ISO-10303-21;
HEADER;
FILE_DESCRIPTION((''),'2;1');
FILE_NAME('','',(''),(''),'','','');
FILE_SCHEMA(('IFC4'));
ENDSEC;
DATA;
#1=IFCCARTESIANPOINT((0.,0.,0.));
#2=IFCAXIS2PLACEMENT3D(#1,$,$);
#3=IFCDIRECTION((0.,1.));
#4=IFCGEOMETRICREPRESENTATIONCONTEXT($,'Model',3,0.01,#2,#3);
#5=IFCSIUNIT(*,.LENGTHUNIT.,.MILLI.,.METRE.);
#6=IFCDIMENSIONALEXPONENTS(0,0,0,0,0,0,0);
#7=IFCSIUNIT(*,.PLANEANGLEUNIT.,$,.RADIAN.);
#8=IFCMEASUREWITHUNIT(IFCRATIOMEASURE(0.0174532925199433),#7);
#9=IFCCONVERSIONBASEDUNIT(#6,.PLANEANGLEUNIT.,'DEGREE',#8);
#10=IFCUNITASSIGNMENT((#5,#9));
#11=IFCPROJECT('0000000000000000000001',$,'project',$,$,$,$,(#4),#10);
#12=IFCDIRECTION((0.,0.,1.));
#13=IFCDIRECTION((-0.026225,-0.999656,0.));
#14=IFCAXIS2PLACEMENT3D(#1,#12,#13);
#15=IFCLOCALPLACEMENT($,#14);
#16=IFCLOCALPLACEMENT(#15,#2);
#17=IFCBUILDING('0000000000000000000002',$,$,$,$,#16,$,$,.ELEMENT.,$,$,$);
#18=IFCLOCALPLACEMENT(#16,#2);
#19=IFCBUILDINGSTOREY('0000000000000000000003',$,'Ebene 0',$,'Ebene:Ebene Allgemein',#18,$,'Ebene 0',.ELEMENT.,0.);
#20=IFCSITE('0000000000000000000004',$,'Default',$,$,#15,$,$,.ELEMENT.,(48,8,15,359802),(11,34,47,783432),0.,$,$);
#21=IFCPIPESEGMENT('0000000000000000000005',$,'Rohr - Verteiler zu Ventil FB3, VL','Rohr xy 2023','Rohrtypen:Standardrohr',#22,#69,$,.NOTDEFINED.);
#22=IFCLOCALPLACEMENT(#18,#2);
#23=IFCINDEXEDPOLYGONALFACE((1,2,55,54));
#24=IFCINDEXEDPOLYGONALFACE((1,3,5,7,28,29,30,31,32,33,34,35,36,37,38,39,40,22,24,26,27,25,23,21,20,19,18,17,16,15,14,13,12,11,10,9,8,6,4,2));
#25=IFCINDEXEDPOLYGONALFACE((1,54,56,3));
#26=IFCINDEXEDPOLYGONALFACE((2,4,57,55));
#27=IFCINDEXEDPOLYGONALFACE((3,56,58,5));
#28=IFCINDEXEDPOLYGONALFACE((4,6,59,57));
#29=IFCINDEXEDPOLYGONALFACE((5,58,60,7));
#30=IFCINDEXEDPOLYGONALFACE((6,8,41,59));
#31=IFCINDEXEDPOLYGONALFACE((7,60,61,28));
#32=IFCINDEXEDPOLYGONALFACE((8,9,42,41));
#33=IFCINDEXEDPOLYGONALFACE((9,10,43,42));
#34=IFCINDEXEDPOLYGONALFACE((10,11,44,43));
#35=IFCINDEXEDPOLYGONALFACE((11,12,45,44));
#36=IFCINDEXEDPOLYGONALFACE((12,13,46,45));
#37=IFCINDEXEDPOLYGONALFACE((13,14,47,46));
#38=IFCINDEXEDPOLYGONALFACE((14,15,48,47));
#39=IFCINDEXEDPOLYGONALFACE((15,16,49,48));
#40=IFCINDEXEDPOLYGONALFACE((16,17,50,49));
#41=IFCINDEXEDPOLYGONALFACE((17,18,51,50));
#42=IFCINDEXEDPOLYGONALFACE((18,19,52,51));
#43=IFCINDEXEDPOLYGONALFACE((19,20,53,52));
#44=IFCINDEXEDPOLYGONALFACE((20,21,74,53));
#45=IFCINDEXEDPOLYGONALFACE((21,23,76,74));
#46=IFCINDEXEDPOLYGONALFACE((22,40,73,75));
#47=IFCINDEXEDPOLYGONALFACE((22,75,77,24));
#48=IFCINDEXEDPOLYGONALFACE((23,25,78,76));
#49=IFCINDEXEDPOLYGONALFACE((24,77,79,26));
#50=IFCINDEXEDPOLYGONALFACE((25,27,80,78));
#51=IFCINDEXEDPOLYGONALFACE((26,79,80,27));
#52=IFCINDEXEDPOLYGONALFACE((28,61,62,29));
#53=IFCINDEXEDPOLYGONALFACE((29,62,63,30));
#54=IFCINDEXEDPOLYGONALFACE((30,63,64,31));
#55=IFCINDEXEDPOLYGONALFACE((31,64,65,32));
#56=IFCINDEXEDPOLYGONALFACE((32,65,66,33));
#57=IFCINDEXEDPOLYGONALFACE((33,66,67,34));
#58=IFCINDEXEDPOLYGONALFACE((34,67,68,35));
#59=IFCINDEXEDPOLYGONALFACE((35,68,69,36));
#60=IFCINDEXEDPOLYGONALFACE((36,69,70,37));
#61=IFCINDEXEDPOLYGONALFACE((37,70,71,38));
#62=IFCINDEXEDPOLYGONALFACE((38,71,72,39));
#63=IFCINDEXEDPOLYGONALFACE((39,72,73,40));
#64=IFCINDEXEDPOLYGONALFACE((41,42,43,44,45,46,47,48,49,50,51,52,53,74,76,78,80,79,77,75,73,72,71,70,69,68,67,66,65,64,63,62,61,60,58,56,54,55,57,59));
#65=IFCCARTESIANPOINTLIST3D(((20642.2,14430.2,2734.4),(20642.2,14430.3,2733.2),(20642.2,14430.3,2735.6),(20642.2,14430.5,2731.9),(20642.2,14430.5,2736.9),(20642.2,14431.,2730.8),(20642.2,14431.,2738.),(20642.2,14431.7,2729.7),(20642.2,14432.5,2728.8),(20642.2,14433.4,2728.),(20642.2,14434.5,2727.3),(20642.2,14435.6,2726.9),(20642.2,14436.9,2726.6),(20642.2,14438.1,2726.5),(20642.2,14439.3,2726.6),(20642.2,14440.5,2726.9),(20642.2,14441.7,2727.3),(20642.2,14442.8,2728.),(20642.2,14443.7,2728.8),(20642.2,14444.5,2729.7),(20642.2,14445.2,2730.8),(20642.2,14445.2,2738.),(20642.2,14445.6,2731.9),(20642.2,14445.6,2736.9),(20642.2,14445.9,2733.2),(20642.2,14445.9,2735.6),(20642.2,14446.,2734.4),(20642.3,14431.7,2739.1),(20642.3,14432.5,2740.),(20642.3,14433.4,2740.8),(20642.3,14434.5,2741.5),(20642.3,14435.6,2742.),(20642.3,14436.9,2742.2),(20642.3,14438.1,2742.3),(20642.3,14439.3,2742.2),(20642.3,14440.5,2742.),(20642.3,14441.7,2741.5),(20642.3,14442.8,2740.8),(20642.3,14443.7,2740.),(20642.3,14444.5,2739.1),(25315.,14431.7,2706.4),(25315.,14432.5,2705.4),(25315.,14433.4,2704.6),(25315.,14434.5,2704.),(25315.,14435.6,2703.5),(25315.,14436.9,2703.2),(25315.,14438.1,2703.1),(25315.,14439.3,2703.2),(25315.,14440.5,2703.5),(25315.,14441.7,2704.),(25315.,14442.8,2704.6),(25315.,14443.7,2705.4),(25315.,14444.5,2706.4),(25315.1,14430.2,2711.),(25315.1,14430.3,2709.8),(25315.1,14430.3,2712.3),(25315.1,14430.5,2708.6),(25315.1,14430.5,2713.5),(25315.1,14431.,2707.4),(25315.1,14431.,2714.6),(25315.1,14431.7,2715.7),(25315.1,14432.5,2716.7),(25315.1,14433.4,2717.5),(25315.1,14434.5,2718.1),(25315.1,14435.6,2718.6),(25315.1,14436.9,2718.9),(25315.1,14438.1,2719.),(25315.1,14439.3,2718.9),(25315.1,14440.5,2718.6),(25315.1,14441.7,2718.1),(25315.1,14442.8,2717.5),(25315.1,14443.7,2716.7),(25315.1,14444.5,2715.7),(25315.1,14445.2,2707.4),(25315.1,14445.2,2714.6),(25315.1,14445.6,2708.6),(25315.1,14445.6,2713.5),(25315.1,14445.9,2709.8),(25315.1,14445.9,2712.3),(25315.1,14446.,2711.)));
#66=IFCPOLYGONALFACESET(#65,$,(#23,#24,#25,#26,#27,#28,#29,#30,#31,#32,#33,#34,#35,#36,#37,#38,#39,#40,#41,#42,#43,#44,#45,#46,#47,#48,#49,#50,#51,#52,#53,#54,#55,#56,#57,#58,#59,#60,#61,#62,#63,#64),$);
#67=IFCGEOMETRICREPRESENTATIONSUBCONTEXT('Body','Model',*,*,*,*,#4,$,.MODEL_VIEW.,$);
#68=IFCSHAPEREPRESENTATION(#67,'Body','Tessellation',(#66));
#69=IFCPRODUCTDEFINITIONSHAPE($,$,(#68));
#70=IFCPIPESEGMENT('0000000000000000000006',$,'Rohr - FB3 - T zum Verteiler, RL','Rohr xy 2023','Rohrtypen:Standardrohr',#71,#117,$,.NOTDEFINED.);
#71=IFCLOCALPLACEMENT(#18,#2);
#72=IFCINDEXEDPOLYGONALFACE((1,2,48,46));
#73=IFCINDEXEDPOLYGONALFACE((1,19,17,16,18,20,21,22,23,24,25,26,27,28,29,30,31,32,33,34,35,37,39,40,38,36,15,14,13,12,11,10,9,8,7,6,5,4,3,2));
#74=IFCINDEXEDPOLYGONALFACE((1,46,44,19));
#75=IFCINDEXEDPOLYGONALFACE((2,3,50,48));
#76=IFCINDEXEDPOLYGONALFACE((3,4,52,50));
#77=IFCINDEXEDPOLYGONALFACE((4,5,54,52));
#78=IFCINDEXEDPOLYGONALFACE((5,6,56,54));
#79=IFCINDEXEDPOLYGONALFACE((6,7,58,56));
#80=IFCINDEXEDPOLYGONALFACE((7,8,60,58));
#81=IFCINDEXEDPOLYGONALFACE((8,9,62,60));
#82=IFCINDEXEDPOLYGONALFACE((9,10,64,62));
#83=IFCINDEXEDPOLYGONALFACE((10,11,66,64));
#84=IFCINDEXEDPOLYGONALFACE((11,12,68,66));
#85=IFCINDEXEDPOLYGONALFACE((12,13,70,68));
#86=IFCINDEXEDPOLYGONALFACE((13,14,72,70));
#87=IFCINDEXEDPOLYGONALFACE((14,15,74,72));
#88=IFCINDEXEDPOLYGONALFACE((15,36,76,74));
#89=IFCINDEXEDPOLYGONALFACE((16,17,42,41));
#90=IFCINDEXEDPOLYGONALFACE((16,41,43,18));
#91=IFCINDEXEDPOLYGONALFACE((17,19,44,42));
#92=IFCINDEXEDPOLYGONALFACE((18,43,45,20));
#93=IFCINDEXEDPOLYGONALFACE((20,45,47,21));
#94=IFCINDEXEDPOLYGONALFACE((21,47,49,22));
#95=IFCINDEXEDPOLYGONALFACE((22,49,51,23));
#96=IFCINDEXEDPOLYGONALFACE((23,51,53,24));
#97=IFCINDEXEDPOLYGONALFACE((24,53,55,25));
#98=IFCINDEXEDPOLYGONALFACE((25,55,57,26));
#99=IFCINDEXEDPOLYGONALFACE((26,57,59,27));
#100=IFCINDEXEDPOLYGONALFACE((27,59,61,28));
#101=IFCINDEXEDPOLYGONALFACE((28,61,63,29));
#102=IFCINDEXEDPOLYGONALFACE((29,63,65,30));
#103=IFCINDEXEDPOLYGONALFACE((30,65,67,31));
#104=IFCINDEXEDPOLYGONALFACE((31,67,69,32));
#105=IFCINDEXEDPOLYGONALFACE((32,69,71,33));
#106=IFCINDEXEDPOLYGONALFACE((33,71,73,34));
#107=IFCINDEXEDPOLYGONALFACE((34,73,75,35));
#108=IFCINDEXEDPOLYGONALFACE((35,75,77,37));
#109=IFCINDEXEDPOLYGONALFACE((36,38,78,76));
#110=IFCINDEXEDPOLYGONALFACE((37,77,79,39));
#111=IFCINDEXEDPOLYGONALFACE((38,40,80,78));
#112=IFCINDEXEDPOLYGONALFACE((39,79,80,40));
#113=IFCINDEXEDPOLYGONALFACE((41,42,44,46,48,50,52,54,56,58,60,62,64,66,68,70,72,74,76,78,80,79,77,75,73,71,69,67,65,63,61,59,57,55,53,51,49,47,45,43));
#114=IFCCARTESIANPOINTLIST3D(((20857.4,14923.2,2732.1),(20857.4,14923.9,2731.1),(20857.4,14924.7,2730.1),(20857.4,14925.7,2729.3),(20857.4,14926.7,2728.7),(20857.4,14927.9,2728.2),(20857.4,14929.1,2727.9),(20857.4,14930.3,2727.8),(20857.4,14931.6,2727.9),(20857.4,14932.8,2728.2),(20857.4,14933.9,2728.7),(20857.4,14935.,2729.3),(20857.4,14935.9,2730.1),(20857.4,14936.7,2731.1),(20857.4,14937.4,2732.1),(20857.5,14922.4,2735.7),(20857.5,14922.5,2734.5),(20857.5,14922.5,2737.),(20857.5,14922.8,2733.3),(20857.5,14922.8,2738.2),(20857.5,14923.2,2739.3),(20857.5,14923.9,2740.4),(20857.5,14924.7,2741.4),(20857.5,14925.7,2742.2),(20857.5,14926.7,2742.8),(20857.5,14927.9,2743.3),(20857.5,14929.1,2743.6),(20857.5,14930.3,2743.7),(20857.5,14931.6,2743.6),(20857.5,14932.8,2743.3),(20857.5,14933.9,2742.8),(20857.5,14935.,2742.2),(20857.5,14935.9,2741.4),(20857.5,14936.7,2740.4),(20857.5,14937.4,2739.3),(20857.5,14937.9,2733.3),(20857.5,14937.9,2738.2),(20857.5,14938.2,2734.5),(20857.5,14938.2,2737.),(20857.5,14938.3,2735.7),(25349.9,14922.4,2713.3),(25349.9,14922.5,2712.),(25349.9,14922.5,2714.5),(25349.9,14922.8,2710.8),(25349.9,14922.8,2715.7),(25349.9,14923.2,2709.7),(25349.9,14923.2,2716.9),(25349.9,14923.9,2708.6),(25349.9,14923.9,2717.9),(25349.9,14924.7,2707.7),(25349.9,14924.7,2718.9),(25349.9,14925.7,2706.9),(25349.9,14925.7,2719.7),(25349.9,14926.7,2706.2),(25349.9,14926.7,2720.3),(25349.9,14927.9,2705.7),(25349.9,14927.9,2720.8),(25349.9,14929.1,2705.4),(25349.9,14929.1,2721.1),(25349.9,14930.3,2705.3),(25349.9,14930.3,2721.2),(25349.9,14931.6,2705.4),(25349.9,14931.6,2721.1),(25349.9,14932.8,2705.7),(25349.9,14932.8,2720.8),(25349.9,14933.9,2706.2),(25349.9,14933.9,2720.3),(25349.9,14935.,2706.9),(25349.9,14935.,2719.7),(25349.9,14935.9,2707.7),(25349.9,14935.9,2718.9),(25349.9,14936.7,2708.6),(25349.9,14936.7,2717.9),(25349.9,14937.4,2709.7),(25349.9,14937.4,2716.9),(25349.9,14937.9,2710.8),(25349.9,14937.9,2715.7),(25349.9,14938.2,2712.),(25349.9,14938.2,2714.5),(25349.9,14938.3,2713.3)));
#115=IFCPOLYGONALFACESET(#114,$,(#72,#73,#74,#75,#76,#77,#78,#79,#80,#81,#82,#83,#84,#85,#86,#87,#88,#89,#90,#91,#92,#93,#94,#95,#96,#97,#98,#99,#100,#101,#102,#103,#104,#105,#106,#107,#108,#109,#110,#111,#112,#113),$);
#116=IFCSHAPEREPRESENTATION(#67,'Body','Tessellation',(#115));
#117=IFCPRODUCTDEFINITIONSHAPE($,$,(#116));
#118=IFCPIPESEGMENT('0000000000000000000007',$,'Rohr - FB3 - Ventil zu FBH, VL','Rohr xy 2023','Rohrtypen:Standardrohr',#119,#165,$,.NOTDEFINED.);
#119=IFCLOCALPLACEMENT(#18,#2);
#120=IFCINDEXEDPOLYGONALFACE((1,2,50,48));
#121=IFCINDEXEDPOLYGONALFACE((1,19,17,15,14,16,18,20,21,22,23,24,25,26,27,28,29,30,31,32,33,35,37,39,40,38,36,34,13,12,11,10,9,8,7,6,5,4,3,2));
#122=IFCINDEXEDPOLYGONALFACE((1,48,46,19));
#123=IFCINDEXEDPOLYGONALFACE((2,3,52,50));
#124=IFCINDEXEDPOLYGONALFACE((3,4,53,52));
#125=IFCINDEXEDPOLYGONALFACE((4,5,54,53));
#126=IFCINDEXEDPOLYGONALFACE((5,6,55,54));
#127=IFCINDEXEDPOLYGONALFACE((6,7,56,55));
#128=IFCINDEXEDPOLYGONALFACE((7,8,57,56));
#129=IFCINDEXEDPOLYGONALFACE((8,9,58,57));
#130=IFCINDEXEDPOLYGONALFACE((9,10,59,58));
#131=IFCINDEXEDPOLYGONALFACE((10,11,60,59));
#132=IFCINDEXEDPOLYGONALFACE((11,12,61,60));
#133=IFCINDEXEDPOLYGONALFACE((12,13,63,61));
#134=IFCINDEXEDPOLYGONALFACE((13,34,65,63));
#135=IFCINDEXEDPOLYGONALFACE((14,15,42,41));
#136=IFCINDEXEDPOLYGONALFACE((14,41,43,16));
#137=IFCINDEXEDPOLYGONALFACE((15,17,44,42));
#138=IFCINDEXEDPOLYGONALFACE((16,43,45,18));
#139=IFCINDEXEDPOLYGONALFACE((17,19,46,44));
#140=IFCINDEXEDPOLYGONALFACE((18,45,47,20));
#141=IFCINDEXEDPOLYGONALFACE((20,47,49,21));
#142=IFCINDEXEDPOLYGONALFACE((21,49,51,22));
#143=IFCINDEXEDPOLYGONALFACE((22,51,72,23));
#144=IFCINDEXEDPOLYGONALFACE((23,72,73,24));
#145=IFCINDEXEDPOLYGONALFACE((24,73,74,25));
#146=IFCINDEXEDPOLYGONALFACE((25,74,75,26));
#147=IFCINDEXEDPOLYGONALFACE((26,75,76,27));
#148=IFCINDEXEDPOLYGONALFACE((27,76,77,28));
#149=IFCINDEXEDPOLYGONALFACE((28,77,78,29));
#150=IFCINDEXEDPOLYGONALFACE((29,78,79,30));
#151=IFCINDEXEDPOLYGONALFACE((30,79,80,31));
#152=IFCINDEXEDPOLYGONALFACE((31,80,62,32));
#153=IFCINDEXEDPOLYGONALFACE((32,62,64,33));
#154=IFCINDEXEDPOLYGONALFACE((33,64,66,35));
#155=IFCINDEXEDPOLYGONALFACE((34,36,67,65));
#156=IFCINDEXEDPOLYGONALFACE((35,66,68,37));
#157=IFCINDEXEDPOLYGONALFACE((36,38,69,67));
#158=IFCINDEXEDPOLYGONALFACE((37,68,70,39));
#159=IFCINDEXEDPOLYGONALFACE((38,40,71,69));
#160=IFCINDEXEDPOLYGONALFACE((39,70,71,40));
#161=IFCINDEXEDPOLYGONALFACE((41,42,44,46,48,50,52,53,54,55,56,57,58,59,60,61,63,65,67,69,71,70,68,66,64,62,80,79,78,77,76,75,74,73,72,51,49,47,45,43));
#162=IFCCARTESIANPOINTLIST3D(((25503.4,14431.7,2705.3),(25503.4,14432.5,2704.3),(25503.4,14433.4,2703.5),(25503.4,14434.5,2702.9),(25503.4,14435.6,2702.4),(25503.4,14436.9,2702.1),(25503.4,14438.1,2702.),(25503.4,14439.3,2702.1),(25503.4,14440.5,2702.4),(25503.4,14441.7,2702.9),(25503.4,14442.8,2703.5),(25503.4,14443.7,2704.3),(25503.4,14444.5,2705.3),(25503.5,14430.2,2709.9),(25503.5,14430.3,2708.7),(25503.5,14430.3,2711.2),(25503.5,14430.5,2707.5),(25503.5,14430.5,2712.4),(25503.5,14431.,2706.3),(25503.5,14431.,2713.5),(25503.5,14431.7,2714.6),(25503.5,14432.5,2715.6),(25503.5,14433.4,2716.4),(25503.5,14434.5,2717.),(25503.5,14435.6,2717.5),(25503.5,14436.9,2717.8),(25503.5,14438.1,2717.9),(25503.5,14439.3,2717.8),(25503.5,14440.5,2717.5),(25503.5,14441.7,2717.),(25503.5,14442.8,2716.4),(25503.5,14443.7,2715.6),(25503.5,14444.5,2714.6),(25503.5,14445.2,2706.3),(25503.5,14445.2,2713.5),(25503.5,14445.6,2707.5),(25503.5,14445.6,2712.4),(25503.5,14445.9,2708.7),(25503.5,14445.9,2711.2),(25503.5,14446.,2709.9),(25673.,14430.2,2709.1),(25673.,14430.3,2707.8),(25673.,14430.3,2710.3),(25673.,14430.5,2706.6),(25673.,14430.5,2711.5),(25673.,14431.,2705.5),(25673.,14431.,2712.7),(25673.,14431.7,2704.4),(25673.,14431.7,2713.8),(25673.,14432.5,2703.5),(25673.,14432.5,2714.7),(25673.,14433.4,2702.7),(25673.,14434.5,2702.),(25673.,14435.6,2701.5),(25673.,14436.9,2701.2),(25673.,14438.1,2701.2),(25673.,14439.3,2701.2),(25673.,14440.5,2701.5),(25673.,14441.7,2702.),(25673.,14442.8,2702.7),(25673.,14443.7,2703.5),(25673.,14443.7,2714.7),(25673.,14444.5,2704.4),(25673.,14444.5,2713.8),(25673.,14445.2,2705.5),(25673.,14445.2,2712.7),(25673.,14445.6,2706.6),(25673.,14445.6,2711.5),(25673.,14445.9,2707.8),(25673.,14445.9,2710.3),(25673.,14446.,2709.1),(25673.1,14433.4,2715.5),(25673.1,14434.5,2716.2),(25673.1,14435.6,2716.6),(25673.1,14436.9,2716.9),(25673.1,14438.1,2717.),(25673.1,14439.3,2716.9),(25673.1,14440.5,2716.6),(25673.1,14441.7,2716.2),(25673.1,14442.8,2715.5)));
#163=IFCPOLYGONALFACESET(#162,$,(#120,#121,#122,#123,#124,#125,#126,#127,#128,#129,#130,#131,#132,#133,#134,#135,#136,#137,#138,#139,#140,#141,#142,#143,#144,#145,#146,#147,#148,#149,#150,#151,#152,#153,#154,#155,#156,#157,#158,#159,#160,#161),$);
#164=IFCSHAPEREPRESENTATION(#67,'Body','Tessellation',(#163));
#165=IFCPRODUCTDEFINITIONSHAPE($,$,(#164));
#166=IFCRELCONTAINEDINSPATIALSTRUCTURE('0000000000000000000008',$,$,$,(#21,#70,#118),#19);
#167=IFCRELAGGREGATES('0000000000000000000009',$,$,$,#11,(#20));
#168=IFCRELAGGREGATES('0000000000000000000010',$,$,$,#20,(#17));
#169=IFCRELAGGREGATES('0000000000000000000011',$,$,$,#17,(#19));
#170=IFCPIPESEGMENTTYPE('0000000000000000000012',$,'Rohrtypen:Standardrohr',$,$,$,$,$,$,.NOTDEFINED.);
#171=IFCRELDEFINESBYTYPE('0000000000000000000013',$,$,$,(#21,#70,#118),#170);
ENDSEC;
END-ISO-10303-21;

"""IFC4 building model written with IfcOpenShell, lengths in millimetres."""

from ifc_helpers import new_model, entity, si_unit, converted_unit, direction, frame, origin, place, context, subcontext, project, spatial, indexed_curve, outline, extrude, type_object, element, save


model = new_model("IFC4")

# Units and contexts
model_context = context("Model", 3, precision=0.01, world=origin(), true_north=direction((0.0, 1.0)))
body_context = subcontext(model_context, "Body", "Model", "MODEL_VIEW")
ifc_project = project(units=[si_unit("LENGTHUNIT", "METRE", prefix="MILLI"), converted_unit("PLANEANGLEUNIT", "DEGREE", entity("IfcRatioMeasure", 0.0174532925199433), si_unit("PLANEANGLEUNIT", "RADIAN"), dimensions=[0, 0, 0, 0, 0, 0, 0])], contexts=[model_context])

# Site, building, storey
site_placement = place(None, frame((0.0, 0.0, 0.0), z_axis=(0.0, 0.0, 1.0), x_axis=(-0.026225, -0.999656, 0.0)))
site = spatial("IfcSite", under=ifc_project, at=site_placement, Name="Default", CompositionType="ELEMENT", RefLatitude=(48, 8, 15, 359802), RefLongitude=(11, 34, 47, 783432), RefElevation=0.0)
building_placement = place(site_placement, origin())
building = spatial("IfcBuilding", under=site, at=building_placement, CompositionType="ELEMENT")
storey_placement = place(building_placement, origin())
storey = spatial("IfcBuildingStorey", under=building, at=storey_placement, Name="Ebene 0", ObjectType="Ebene:Ebene Allgemein", LongName="Ebene 0", CompositionType="ELEMENT", Elevation=0.0)

# Pipe segments
pipe_segment_type = type_object("IfcPipeSegmentType", Name="Rohrtypen:Standardrohr", PredefinedType="NOTDEFINED")
pipe_segment_1_placement = place(storey_placement, origin())
element("IfcPipeSegment", 1, at=pipe_segment_1_placement, inside=storey, type_object=pipe_segment_type, Name="Rohr - Verteiler zu Ventil FB3, VL", Description="Rohr xy 2023", ObjectType="Rohrtypen:Standardrohr", PredefinedType="NOTDEFINED", context=body_context, shape_type="SweptSolid", body=[
    extrude(outline(indexed_curve([(7.9, 0.0), (7.8, 1.2), (7.6, 2.5), (7.1, 3.6), (6.4, 4.7), (5.6, 5.6), (4.7, 6.4), (3.6, 7.1), (2.5, 7.6), (1.2, 7.8), (0.0, 7.9), (-1.2, 7.8), (-2.5, 7.6), (-3.6, 7.1), (-4.7, 6.4), (-5.6, 5.6), (-6.4, 4.7), (-7.1, 3.6), (-7.6, 2.5), (-7.8, 1.2), (-7.9, 0.0), (-7.8, -1.2), (-7.6, -2.5), (-7.1, -3.6), (-6.4, -4.7), (-5.6, -5.6), (-4.7, -6.4), (-3.6, -7.1), (-2.5, -7.6), (-1.2, -7.8), (0.0, -7.9), (1.2, -7.8), (2.5, -7.6), (3.6, -7.1), (4.7, -6.4), (5.6, -5.6), (6.4, -4.7), (7.1, -3.6), (7.6, -2.5), (7.8, -1.2), (7.9, 0.0)], self_intersect=False)), frame((25315.1, 14438.1, 2711.0), z_axis=(-0.999988, 0.0, 0.005), x_axis=(0.0, 1.0, 0.0)), (0.0, 0.0, 1.0), 4672.9),
])
pipe_segment_2_placement = place(storey_placement, origin())
element("IfcPipeSegment", 2, at=pipe_segment_2_placement, inside=storey, type_object=pipe_segment_type, Name="Rohr - FB3 - T zum Verteiler, RL", Description="Rohr xy 2023", ObjectType="Rohrtypen:Standardrohr", PredefinedType="NOTDEFINED", context=body_context, shape_type="SweptSolid", body=[
    extrude(outline(indexed_curve([(7.9, 0.0), (7.8, 1.2), (7.6, 2.5), (7.1, 3.6), (6.4, 4.7), (5.6, 5.6), (4.7, 6.4), (3.6, 7.1), (2.5, 7.6), (1.2, 7.8), (0.0, 7.9), (-1.2, 7.8), (-2.5, 7.6), (-3.6, 7.1), (-4.7, 6.4), (-5.6, 5.6), (-6.4, 4.7), (-7.1, 3.6), (-7.6, 2.5), (-7.8, 1.2), (-7.9, 0.0), (-7.8, -1.2), (-7.6, -2.5), (-7.1, -3.6), (-6.4, -4.7), (-5.6, -5.6), (-4.7, -6.4), (-3.6, -7.1), (-2.5, -7.6), (-1.2, -7.8), (0.0, -7.9), (1.2, -7.8), (2.5, -7.6), (3.6, -7.1), (4.7, -6.4), (5.6, -5.6), (6.4, -4.7), (7.1, -3.6), (7.6, -2.5), (7.8, -1.2), (7.9, 0.0)], self_intersect=False)), frame((25349.9, 14930.3, 2713.3), z_axis=(-0.999988, 0.0, 0.005), x_axis=(0.0, 1.0, 0.0)), (0.0, 0.0, 1.0), 4492.5),
])
pipe_segment_3_placement = place(storey_placement, origin())
element("IfcPipeSegment", 3, at=pipe_segment_3_placement, inside=storey, type_object=pipe_segment_type, Name="Rohr - FB3 - Ventil zu FBH, VL", Description="Rohr xy 2023", ObjectType="Rohrtypen:Standardrohr", PredefinedType="NOTDEFINED", context=body_context, shape_type="SweptSolid", body=[
    extrude(outline(indexed_curve([(7.9, 0.0), (7.8, 1.2), (7.6, 2.5), (7.1, 3.6), (6.4, 4.7), (5.6, 5.6), (4.7, 6.4), (3.6, 7.1), (2.5, 7.6), (1.2, 7.8), (0.0, 7.9), (-1.2, 7.8), (-2.5, 7.6), (-3.6, 7.1), (-4.7, 6.4), (-5.6, 5.6), (-6.4, 4.7), (-7.1, 3.6), (-7.6, 2.5), (-7.8, 1.2), (-7.9, 0.0), (-7.8, -1.2), (-7.6, -2.5), (-7.1, -3.6), (-6.4, -4.7), (-5.6, -5.6), (-4.7, -6.4), (-3.6, -7.1), (-2.5, -7.6), (-1.2, -7.8), (0.0, -7.9), (1.2, -7.8), (2.5, -7.6), (3.6, -7.1), (4.7, -6.4), (5.6, -5.6), (6.4, -4.7), (7.1, -3.6), (7.6, -2.5), (7.8, -1.2), (7.9, 0.0)], self_intersect=False)), frame((25503.5, 14438.1, 2709.9), z_axis=(0.999988, 0.0, -0.005), x_axis=(0.0, 1.0, 0.0)), (0.0, 0.0, 1.0), 169.5),
])

save(model, "model.ifc")
